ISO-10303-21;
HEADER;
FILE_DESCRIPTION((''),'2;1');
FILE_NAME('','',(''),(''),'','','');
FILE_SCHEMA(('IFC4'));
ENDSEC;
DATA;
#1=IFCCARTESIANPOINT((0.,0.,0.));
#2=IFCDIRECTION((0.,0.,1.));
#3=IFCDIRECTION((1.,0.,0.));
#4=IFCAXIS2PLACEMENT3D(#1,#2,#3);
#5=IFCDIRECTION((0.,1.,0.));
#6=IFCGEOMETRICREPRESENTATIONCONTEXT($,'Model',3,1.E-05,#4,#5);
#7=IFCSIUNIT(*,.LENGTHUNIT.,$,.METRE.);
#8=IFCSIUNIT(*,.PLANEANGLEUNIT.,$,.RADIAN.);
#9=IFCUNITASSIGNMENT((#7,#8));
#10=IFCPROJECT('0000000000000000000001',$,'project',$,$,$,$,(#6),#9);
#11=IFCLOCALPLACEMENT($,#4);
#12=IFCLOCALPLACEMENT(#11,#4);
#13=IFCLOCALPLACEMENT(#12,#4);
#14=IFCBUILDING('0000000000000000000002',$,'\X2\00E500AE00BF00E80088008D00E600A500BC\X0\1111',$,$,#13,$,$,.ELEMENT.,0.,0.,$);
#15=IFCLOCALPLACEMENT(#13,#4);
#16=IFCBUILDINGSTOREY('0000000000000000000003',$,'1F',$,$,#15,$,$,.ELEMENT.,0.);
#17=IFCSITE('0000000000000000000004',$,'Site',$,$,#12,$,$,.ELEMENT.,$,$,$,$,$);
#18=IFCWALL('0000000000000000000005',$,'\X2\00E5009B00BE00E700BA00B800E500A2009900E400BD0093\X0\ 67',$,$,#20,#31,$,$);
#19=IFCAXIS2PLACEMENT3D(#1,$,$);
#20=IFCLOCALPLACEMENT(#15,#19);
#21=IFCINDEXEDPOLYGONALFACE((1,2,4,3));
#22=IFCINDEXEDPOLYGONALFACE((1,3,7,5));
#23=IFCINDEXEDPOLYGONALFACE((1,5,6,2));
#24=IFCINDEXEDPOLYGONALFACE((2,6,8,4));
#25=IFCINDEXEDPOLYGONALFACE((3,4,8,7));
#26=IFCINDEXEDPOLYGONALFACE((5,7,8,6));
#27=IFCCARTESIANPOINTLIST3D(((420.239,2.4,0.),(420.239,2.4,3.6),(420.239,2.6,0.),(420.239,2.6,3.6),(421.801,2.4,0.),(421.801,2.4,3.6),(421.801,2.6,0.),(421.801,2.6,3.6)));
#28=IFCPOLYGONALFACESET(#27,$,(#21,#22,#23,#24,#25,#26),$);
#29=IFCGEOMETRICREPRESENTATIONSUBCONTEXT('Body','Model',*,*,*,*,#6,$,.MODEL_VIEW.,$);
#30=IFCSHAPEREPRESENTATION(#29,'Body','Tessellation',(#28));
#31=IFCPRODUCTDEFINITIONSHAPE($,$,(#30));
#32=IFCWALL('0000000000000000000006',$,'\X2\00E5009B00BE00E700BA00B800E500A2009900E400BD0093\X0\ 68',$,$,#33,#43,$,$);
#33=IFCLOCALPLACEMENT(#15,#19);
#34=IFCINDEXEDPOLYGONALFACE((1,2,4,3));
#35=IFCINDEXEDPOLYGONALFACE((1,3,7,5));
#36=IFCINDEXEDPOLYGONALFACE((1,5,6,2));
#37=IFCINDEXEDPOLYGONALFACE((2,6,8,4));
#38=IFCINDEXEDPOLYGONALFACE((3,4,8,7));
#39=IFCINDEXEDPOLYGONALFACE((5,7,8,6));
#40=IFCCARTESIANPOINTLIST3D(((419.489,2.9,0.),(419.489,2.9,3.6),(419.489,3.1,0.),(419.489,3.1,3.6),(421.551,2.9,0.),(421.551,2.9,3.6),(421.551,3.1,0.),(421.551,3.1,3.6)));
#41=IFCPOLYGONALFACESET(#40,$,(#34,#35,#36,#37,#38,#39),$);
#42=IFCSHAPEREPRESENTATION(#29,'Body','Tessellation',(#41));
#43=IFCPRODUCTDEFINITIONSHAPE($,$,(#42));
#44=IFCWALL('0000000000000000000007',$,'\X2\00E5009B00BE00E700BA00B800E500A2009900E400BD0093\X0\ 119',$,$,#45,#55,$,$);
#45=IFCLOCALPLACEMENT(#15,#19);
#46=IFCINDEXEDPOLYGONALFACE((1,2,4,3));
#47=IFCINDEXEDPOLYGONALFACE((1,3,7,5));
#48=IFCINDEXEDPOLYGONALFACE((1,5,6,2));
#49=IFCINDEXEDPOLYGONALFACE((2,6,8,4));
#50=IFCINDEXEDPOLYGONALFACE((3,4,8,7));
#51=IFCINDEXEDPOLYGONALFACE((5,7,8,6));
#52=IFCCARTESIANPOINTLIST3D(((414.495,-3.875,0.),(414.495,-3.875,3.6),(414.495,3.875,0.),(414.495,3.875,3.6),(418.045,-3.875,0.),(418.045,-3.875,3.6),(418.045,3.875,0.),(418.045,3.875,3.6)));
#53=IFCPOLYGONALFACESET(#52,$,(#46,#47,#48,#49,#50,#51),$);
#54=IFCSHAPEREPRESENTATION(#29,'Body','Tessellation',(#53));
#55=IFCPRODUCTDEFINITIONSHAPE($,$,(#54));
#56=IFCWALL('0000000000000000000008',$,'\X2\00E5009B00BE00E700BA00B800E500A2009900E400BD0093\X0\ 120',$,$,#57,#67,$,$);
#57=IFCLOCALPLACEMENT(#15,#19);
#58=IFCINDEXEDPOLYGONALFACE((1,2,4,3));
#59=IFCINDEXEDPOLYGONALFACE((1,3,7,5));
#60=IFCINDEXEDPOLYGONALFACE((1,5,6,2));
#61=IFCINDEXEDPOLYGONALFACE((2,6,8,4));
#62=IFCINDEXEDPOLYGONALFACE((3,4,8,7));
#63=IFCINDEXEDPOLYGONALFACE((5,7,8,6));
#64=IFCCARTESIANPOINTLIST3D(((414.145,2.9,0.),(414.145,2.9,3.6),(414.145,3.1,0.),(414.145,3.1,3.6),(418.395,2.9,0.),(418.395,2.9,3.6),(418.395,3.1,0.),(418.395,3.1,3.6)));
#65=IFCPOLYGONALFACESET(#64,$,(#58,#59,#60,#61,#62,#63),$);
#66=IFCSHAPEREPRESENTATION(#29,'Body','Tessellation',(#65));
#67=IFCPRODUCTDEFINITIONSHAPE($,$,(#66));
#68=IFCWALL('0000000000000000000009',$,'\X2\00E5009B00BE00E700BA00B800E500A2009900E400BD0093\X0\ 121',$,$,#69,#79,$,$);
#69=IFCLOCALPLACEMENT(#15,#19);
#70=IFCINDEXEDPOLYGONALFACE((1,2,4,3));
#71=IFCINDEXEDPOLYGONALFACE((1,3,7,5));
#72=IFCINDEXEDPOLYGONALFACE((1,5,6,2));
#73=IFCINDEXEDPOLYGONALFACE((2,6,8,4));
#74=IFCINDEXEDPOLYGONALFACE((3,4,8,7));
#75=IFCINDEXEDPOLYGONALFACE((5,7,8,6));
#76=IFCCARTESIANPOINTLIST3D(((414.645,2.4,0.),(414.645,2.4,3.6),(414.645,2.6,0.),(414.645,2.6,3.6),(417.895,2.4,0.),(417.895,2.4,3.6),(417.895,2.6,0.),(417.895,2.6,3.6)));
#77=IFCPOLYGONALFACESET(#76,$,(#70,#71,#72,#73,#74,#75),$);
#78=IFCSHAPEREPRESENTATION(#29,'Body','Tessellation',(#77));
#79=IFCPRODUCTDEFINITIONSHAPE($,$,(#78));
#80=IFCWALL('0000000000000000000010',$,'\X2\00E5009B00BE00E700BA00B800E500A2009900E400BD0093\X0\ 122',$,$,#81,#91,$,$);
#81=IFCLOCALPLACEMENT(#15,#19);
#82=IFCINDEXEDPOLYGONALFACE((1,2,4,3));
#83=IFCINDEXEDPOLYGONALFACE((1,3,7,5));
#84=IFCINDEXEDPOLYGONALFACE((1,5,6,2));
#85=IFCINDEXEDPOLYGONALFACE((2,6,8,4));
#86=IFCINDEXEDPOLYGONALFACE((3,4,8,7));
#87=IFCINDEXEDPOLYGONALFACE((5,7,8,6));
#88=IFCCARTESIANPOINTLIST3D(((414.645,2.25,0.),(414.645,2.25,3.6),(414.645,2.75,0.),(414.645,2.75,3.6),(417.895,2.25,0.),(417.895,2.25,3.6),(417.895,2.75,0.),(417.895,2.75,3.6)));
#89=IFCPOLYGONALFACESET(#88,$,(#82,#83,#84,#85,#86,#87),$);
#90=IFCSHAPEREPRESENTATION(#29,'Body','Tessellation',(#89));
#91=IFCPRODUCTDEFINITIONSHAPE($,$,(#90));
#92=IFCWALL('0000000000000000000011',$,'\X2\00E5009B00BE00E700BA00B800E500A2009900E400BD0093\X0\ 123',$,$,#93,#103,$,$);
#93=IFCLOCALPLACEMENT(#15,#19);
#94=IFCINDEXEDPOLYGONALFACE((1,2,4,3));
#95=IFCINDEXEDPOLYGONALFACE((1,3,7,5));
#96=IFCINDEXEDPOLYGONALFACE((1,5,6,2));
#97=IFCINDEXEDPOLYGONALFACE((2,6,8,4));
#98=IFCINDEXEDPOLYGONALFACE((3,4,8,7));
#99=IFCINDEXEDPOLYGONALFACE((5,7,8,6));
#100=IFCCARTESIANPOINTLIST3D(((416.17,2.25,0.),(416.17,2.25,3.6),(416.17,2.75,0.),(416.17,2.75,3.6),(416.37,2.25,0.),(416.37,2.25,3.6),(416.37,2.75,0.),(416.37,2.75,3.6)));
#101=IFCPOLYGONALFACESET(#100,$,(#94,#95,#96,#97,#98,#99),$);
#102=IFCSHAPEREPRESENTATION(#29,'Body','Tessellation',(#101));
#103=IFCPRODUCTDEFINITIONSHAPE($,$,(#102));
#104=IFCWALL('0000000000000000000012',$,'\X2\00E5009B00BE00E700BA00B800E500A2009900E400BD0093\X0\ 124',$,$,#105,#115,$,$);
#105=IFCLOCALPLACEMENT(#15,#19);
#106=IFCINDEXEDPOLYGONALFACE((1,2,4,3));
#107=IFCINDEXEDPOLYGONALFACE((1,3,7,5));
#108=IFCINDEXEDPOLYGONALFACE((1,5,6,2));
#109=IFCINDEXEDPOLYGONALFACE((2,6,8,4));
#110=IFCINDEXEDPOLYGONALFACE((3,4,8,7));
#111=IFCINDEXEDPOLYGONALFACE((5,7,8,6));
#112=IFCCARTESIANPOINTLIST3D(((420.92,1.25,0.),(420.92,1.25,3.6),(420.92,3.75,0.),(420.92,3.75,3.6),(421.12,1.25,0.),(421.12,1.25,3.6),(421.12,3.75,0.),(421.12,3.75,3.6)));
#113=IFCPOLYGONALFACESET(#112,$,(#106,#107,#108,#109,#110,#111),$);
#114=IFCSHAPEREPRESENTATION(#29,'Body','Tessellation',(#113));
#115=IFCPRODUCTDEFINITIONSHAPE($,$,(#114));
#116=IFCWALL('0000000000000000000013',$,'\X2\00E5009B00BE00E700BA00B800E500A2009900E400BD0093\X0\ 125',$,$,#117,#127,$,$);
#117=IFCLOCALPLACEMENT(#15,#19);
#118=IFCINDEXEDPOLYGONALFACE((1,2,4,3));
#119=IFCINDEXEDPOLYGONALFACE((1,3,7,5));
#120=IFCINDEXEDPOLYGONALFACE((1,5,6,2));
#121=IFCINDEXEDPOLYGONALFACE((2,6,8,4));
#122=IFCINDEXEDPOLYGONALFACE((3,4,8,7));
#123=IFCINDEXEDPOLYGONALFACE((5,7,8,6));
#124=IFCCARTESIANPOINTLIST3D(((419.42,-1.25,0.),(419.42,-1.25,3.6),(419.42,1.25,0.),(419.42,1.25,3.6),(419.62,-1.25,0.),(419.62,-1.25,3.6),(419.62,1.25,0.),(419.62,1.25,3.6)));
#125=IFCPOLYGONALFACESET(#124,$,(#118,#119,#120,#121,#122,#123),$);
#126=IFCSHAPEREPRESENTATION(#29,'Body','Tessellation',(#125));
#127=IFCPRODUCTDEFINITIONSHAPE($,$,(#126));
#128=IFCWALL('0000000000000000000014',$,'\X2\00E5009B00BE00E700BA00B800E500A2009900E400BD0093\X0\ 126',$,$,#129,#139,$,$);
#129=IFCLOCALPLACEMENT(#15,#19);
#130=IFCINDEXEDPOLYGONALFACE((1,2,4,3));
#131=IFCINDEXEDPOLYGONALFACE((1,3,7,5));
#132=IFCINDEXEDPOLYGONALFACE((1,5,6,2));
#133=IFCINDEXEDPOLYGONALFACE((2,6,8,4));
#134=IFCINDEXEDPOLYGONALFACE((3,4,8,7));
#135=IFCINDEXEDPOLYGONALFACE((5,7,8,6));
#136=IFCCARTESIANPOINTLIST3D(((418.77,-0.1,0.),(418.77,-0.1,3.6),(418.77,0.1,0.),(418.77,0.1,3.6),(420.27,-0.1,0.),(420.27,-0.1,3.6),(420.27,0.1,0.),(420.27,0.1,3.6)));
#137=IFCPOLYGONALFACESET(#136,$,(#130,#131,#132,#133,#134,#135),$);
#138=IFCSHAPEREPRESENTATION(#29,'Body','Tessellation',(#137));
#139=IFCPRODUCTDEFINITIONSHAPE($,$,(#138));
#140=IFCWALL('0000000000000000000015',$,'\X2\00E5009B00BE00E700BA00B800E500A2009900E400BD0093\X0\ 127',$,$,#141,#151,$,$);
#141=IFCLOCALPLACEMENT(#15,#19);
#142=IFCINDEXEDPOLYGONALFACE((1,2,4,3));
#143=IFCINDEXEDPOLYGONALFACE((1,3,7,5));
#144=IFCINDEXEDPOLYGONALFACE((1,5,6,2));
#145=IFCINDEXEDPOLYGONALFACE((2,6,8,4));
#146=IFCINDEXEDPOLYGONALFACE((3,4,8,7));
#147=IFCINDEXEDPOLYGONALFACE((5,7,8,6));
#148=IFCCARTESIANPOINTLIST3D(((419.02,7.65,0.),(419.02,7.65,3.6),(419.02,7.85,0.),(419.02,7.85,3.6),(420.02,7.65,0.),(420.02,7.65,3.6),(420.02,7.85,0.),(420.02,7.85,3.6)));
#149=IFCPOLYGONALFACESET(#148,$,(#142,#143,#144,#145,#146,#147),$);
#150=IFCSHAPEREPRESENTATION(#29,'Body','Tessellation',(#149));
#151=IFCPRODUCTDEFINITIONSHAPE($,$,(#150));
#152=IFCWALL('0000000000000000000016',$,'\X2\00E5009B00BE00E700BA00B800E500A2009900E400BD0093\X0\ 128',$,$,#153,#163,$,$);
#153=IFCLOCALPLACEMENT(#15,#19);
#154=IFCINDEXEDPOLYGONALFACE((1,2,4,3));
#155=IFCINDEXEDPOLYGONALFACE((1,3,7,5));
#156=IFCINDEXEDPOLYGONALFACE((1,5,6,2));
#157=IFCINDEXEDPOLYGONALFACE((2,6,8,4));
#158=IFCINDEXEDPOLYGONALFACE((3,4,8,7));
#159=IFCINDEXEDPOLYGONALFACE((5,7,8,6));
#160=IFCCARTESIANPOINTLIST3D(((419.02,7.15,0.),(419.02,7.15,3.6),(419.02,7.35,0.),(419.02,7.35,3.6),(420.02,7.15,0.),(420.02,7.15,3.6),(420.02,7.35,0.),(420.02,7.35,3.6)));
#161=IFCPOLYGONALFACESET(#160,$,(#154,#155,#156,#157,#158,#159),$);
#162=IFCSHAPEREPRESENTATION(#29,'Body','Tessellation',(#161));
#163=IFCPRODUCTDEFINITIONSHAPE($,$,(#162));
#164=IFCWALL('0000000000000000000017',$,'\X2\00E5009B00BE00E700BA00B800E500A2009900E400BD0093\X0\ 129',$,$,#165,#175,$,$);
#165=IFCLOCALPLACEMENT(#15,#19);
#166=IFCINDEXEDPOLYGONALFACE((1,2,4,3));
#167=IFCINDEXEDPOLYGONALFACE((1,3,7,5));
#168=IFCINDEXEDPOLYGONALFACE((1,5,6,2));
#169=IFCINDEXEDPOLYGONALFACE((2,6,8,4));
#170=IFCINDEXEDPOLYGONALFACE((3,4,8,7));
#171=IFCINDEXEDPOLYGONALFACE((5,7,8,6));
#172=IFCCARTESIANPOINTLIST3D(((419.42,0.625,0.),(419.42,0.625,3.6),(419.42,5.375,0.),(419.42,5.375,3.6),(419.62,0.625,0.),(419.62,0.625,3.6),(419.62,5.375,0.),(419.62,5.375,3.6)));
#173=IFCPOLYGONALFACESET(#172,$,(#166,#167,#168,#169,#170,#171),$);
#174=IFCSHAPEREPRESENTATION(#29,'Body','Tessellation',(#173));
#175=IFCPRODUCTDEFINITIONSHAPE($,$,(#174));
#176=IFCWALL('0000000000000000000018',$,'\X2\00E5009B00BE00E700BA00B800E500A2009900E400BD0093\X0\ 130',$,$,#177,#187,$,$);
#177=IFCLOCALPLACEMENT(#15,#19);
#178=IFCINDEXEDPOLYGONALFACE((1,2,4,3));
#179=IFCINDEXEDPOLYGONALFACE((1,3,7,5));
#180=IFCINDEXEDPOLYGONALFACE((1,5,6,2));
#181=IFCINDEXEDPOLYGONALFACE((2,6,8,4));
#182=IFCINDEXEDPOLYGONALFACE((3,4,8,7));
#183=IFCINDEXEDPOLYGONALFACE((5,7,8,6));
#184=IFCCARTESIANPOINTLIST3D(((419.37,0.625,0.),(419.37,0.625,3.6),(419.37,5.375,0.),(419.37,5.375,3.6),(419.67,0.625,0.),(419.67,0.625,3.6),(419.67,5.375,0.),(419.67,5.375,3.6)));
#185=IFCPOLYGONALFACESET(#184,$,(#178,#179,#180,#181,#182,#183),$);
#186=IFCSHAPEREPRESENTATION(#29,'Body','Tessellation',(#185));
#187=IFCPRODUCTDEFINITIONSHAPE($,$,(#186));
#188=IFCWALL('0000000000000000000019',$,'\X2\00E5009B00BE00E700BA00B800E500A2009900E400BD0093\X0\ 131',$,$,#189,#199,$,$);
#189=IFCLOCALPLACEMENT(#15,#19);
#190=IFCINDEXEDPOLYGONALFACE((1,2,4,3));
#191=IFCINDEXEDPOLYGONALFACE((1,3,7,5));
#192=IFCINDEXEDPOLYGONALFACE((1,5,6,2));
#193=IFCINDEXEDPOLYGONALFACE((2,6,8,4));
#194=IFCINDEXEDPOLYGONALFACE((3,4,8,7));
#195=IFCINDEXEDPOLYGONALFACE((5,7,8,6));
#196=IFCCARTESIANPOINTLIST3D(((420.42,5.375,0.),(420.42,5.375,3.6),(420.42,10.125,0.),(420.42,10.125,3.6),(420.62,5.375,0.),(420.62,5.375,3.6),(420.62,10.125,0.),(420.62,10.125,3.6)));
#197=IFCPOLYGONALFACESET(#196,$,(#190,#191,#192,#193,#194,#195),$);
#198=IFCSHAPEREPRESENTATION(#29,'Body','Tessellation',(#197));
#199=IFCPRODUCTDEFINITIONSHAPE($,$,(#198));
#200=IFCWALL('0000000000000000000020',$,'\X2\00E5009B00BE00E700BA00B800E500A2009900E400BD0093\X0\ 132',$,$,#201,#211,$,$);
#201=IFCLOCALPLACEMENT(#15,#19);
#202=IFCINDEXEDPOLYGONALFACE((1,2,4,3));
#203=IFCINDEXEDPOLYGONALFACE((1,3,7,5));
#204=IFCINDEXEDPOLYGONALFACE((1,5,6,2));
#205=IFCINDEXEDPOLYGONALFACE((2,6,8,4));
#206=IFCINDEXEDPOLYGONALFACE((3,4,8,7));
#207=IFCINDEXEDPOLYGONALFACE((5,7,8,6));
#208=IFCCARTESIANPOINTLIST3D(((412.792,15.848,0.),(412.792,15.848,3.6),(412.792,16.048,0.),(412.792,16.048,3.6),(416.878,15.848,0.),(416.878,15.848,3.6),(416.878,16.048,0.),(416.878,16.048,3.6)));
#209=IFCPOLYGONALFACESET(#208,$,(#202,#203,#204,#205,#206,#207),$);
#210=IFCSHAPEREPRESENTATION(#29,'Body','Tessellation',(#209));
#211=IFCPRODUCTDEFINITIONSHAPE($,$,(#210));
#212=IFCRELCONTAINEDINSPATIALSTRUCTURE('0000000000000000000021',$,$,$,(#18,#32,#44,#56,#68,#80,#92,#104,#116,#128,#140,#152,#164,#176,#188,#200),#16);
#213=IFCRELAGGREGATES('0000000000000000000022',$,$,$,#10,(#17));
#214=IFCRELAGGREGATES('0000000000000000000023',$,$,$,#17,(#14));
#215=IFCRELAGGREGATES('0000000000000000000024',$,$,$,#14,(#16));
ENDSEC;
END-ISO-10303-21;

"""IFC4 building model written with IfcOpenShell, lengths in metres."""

from ifc_helpers import new_model, si_unit, direction, frame, frame_2d, origin_with_axes, place, context, subcontext, project, spatial, rectangle, extrude, element, save


model = new_model("IFC4")

# Units and contexts
model_context = context("Model", 3, precision=1e-05, world=origin_with_axes(), true_north=direction((0.0, 1.0, 0.0)))
body_context = subcontext(model_context, "Body", "Model", "MODEL_VIEW")
ifc_project = project(units=[si_unit("LENGTHUNIT", "METRE"), si_unit("PLANEANGLEUNIT", "RADIAN")], contexts=[model_context])

# Site, building, storey
placement = place(None, origin_with_axes())
site_placement = place(placement, origin_with_axes())
site = spatial("IfcSite", under=ifc_project, at=site_placement, Name="Site", CompositionType="ELEMENT")
building_placement = place(site_placement, origin_with_axes())
building = spatial("IfcBuilding", under=site, at=building_placement, Name="å®¿è\u0088\u008dæ¥¼1111", CompositionType="ELEMENT", ElevationOfRefHeight=0.0, ElevationOfTerrain=0.0)
storey_placement = place(building_placement, origin_with_axes())
storey = spatial("IfcBuildingStorey", under=building, at=storey_placement, Name="1F", CompositionType="ELEMENT", Elevation=0.0)

# Walls
wall_1_placement = place(storey_placement, frame((421.02, 2.5, 0.0), z_axis=(0.0, 0.0, 1.0), x_axis=(1.0, 0.0, 0.0)))
element("IfcWall", 1, at=wall_1_placement, inside=storey, Name="å\u009b¾çº¸å¢\u0099ä½\u0093 67", context=body_context, shape_type="SweptSolid", body=[
    extrude(rectangle(XDim=1.562, YDim=0.2, at=frame_2d((0.0, 0.0), x_axis=(1.0, 0.0, 0.0))), frame((0.0, 0.0, 0.0), z_axis=(0.0, 0.0, 1.0)), (0.0, 0.0, 1.0), 3.6),
])
wall_2_placement = place(storey_placement, frame((420.52, 3.0, 0.0), z_axis=(0.0, 0.0, 1.0), x_axis=(1.0, 0.0, 0.0)))
element("IfcWall", 2, at=wall_2_placement, inside=storey, Name="å\u009b¾çº¸å¢\u0099ä½\u0093 68", context=body_context, shape_type="SweptSolid", body=[
    extrude(rectangle(XDim=2.062, YDim=0.2, at=frame_2d((0.0, 0.0), x_axis=(1.0, 0.0, 0.0))), frame((0.0, 0.0, 0.0), z_axis=(0.0, 0.0, 1.0)), (0.0, 0.0, 1.0), 3.6),
])
wall_3_placement = place(storey_placement, frame((416.27, 0.0, 0.0), z_axis=(0.0, 0.0, 1.0), x_axis=(1.0, 0.0, 0.0)))
element("IfcWall", 3, at=wall_3_placement, inside=storey, Name="å\u009b¾çº¸å¢\u0099ä½\u0093 119", context=body_context, shape_type="SweptSolid", body=[
    extrude(rectangle(XDim=3.55, YDim=7.75, at=frame_2d((0.0, 0.0), x_axis=(1.0, 0.0, 0.0))), frame((0.0, 0.0, 0.0), z_axis=(0.0, 0.0, 1.0)), (0.0, 0.0, 1.0), 3.6),
])
wall_4_placement = place(storey_placement, frame((416.27, 3.0, 0.0), z_axis=(0.0, 0.0, 1.0), x_axis=(1.0, 0.0, 0.0)))
element("IfcWall", 4, at=wall_4_placement, inside=storey, Name="å\u009b¾çº¸å¢\u0099ä½\u0093 120", context=body_context, shape_type="SweptSolid", body=[
    extrude(rectangle(XDim=4.25, YDim=0.2, at=frame_2d((0.0, 0.0), x_axis=(1.0, 0.0, 0.0))), frame((0.0, 0.0, 0.0), z_axis=(0.0, 0.0, 1.0)), (0.0, 0.0, 1.0), 3.6),
])
wall_5_placement = place(storey_placement, frame((416.27, 2.5, 0.0), z_axis=(0.0, 0.0, 1.0), x_axis=(1.0, 0.0, 0.0)))
element("IfcWall", 5, at=wall_5_placement, inside=storey, Name="å\u009b¾çº¸å¢\u0099ä½\u0093 121", context=body_context, shape_type="SweptSolid", body=[
    extrude(rectangle(XDim=3.25, YDim=0.2, at=frame_2d((0.0, 0.0), x_axis=(1.0, 0.0, 0.0))), frame((0.0, 0.0, 0.0), z_axis=(0.0, 0.0, 1.0)), (0.0, 0.0, 1.0), 3.6),
])
wall_6_placement = place(storey_placement, frame((416.27, 2.5, 0.0), z_axis=(0.0, 0.0, 1.0), x_axis=(1.0, 0.0, 0.0)))
element("IfcWall", 6, at=wall_6_placement, inside=storey, Name="å\u009b¾çº¸å¢\u0099ä½\u0093 122", context=body_context, shape_type="SweptSolid", body=[
    extrude(rectangle(XDim=3.25, YDim=0.5, at=frame_2d((0.0, 0.0), x_axis=(1.0, 0.0, 0.0))), frame((0.0, 0.0, 0.0), z_axis=(0.0, 0.0, 1.0)), (0.0, 0.0, 1.0), 3.6),
])
wall_7_placement = place(storey_placement, frame((416.27, 2.5, 0.0), z_axis=(0.0, 0.0, 1.0), x_axis=(0.0, 1.0, 0.0)))
element("IfcWall", 7, at=wall_7_placement, inside=storey, Name="å\u009b¾çº¸å¢\u0099ä½\u0093 123", context=body_context, shape_type="SweptSolid", body=[
    extrude(rectangle(XDim=0.5, YDim=0.2, at=frame_2d((0.0, 0.0), x_axis=(1.0, 0.0, 0.0))), frame((0.0, 0.0, 0.0), z_axis=(0.0, 0.0, 1.0)), (0.0, 0.0, 1.0), 3.6),
])
for number, where, z_axis, x_axis, name in (
    (8, (421.02, 2.5, 0.0), (0.0, 0.0, 1.0), (0.0, -1.0, 0.0), "å\u009b¾çº¸å¢\u0099ä½\u0093 124"),
    (9, (419.52, 0.0, 0.0), (0.0, 0.0, 1.0), (0.0, 1.0, 0.0), "å\u009b¾çº¸å¢\u0099ä½\u0093 125"),
):
    element("IfcWall", number, at=place(storey_placement, frame(where, z_axis=z_axis, x_axis=x_axis)), inside=storey, Name=name, context=body_context, shape_type="SweptSolid", body=[
        extrude(rectangle(XDim=2.5, YDim=0.2, at=frame_2d((0.0, 0.0), x_axis=(1.0, 0.0, 0.0))), frame((0.0, 0.0, 0.0), z_axis=(0.0, 0.0, 1.0)), (0.0, 0.0, 1.0), 3.6),
    ])
wall_8_placement = place(storey_placement, frame((419.52, 0.0, 0.0), z_axis=(0.0, 0.0, 1.0), x_axis=(1.0, 0.0, 0.0)))
element("IfcWall", 10, at=wall_8_placement, inside=storey, Name="å\u009b¾çº¸å¢\u0099ä½\u0093 126", context=body_context, shape_type="SweptSolid", body=[
    extrude(rectangle(XDim=1.5, YDim=0.2, at=frame_2d((0.0, 0.0), x_axis=(1.0, 0.0, 0.0))), frame((0.0, 0.0, 0.0), z_axis=(0.0, 0.0, 1.0)), (0.0, 0.0, 1.0), 3.6),
])
for number, where, z_axis, x_axis, name in (
    (11, (419.52, 7.75, 0.0), (0.0, 0.0, 1.0), (1.0, 0.0, 0.0), "å\u009b¾çº¸å¢\u0099ä½\u0093 127"),
    (12, (419.52, 7.25, 0.0), (0.0, 0.0, 1.0), (1.0, 0.0, 0.0), "å\u009b¾çº¸å¢\u0099ä½\u0093 128"),
):
    element("IfcWall", number, at=place(storey_placement, frame(where, z_axis=z_axis, x_axis=x_axis)), inside=storey, Name=name, context=body_context, shape_type="SweptSolid", body=[
        extrude(rectangle(XDim=1.0, YDim=0.2, at=frame_2d((0.0, 0.0), x_axis=(1.0, 0.0, 0.0))), frame((0.0, 0.0, 0.0), z_axis=(0.0, 0.0, 1.0)), (0.0, 0.0, 1.0), 3.6),
    ])
wall_9_placement = place(storey_placement, frame((419.52, 3.0, 0.0), z_axis=(0.0, 0.0, 1.0), x_axis=(0.0, 1.0, 0.0)))
element("IfcWall", 13, at=wall_9_placement, inside=storey, Name="å\u009b¾çº¸å¢\u0099ä½\u0093 129", context=body_context, shape_type="SweptSolid", body=[
    extrude(rectangle(XDim=4.75, YDim=0.2, at=frame_2d((0.0, 0.0), x_axis=(1.0, 0.0, 0.0))), frame((0.0, 0.0, 0.0), z_axis=(0.0, 0.0, 1.0)), (0.0, 0.0, 1.0), 3.6),
])
wall_10_placement = place(storey_placement, frame((419.52, 3.0, 0.0), z_axis=(0.0, 0.0, 1.0), x_axis=(1.0, 0.0, 0.0)))
element("IfcWall", 14, at=wall_10_placement, inside=storey, Name="å\u009b¾çº¸å¢\u0099ä½\u0093 130", context=body_context, shape_type="SweptSolid", body=[
    extrude(rectangle(XDim=0.3, YDim=4.75, at=frame_2d((0.0, 0.0), x_axis=(1.0, 0.0, 0.0))), frame((0.0, 0.0, 0.0), z_axis=(0.0, 0.0, 1.0)), (0.0, 0.0, 1.0), 3.6),
])
wall_11_placement = place(storey_placement, frame((420.52, 7.75, 0.0), z_axis=(0.0, 0.0, 1.0), x_axis=(0.0, -1.0, 0.0)))
element("IfcWall", 15, at=wall_11_placement, inside=storey, Name="å\u009b¾çº¸å¢\u0099ä½\u0093 131", context=body_context, shape_type="SweptSolid", body=[
    extrude(rectangle(XDim=4.75, YDim=0.2, at=frame_2d((0.0, 0.0), x_axis=(1.0, 0.0, 0.0))), frame((0.0, 0.0, 0.0), z_axis=(0.0, 0.0, 1.0)), (0.0, 0.0, 1.0), 3.6),
])
for number, where, z_axis, x_axis, name in (
    (16, (414.835, 15.948, 0.0), (0.0, 0.0, 1.0), (1.0, 0.0, 0.0), "å\u009b¾çº¸å¢\u0099ä½\u0093 132"),
):
    element("IfcWall", number, at=place(storey_placement, frame(where, z_axis=z_axis, x_axis=x_axis)), inside=storey, Name=name, context=body_context, shape_type="SweptSolid", body=[
        extrude(rectangle(XDim=4.086, YDim=0.2, at=frame_2d((0.0, 0.0), x_axis=(1.0, 0.0, 0.0))), frame((0.0, 0.0, 0.0), z_axis=(0.0, 0.0, 1.0)), (0.0, 0.0, 1.0), 3.6),
    ])

save(model, "model.ifc")
